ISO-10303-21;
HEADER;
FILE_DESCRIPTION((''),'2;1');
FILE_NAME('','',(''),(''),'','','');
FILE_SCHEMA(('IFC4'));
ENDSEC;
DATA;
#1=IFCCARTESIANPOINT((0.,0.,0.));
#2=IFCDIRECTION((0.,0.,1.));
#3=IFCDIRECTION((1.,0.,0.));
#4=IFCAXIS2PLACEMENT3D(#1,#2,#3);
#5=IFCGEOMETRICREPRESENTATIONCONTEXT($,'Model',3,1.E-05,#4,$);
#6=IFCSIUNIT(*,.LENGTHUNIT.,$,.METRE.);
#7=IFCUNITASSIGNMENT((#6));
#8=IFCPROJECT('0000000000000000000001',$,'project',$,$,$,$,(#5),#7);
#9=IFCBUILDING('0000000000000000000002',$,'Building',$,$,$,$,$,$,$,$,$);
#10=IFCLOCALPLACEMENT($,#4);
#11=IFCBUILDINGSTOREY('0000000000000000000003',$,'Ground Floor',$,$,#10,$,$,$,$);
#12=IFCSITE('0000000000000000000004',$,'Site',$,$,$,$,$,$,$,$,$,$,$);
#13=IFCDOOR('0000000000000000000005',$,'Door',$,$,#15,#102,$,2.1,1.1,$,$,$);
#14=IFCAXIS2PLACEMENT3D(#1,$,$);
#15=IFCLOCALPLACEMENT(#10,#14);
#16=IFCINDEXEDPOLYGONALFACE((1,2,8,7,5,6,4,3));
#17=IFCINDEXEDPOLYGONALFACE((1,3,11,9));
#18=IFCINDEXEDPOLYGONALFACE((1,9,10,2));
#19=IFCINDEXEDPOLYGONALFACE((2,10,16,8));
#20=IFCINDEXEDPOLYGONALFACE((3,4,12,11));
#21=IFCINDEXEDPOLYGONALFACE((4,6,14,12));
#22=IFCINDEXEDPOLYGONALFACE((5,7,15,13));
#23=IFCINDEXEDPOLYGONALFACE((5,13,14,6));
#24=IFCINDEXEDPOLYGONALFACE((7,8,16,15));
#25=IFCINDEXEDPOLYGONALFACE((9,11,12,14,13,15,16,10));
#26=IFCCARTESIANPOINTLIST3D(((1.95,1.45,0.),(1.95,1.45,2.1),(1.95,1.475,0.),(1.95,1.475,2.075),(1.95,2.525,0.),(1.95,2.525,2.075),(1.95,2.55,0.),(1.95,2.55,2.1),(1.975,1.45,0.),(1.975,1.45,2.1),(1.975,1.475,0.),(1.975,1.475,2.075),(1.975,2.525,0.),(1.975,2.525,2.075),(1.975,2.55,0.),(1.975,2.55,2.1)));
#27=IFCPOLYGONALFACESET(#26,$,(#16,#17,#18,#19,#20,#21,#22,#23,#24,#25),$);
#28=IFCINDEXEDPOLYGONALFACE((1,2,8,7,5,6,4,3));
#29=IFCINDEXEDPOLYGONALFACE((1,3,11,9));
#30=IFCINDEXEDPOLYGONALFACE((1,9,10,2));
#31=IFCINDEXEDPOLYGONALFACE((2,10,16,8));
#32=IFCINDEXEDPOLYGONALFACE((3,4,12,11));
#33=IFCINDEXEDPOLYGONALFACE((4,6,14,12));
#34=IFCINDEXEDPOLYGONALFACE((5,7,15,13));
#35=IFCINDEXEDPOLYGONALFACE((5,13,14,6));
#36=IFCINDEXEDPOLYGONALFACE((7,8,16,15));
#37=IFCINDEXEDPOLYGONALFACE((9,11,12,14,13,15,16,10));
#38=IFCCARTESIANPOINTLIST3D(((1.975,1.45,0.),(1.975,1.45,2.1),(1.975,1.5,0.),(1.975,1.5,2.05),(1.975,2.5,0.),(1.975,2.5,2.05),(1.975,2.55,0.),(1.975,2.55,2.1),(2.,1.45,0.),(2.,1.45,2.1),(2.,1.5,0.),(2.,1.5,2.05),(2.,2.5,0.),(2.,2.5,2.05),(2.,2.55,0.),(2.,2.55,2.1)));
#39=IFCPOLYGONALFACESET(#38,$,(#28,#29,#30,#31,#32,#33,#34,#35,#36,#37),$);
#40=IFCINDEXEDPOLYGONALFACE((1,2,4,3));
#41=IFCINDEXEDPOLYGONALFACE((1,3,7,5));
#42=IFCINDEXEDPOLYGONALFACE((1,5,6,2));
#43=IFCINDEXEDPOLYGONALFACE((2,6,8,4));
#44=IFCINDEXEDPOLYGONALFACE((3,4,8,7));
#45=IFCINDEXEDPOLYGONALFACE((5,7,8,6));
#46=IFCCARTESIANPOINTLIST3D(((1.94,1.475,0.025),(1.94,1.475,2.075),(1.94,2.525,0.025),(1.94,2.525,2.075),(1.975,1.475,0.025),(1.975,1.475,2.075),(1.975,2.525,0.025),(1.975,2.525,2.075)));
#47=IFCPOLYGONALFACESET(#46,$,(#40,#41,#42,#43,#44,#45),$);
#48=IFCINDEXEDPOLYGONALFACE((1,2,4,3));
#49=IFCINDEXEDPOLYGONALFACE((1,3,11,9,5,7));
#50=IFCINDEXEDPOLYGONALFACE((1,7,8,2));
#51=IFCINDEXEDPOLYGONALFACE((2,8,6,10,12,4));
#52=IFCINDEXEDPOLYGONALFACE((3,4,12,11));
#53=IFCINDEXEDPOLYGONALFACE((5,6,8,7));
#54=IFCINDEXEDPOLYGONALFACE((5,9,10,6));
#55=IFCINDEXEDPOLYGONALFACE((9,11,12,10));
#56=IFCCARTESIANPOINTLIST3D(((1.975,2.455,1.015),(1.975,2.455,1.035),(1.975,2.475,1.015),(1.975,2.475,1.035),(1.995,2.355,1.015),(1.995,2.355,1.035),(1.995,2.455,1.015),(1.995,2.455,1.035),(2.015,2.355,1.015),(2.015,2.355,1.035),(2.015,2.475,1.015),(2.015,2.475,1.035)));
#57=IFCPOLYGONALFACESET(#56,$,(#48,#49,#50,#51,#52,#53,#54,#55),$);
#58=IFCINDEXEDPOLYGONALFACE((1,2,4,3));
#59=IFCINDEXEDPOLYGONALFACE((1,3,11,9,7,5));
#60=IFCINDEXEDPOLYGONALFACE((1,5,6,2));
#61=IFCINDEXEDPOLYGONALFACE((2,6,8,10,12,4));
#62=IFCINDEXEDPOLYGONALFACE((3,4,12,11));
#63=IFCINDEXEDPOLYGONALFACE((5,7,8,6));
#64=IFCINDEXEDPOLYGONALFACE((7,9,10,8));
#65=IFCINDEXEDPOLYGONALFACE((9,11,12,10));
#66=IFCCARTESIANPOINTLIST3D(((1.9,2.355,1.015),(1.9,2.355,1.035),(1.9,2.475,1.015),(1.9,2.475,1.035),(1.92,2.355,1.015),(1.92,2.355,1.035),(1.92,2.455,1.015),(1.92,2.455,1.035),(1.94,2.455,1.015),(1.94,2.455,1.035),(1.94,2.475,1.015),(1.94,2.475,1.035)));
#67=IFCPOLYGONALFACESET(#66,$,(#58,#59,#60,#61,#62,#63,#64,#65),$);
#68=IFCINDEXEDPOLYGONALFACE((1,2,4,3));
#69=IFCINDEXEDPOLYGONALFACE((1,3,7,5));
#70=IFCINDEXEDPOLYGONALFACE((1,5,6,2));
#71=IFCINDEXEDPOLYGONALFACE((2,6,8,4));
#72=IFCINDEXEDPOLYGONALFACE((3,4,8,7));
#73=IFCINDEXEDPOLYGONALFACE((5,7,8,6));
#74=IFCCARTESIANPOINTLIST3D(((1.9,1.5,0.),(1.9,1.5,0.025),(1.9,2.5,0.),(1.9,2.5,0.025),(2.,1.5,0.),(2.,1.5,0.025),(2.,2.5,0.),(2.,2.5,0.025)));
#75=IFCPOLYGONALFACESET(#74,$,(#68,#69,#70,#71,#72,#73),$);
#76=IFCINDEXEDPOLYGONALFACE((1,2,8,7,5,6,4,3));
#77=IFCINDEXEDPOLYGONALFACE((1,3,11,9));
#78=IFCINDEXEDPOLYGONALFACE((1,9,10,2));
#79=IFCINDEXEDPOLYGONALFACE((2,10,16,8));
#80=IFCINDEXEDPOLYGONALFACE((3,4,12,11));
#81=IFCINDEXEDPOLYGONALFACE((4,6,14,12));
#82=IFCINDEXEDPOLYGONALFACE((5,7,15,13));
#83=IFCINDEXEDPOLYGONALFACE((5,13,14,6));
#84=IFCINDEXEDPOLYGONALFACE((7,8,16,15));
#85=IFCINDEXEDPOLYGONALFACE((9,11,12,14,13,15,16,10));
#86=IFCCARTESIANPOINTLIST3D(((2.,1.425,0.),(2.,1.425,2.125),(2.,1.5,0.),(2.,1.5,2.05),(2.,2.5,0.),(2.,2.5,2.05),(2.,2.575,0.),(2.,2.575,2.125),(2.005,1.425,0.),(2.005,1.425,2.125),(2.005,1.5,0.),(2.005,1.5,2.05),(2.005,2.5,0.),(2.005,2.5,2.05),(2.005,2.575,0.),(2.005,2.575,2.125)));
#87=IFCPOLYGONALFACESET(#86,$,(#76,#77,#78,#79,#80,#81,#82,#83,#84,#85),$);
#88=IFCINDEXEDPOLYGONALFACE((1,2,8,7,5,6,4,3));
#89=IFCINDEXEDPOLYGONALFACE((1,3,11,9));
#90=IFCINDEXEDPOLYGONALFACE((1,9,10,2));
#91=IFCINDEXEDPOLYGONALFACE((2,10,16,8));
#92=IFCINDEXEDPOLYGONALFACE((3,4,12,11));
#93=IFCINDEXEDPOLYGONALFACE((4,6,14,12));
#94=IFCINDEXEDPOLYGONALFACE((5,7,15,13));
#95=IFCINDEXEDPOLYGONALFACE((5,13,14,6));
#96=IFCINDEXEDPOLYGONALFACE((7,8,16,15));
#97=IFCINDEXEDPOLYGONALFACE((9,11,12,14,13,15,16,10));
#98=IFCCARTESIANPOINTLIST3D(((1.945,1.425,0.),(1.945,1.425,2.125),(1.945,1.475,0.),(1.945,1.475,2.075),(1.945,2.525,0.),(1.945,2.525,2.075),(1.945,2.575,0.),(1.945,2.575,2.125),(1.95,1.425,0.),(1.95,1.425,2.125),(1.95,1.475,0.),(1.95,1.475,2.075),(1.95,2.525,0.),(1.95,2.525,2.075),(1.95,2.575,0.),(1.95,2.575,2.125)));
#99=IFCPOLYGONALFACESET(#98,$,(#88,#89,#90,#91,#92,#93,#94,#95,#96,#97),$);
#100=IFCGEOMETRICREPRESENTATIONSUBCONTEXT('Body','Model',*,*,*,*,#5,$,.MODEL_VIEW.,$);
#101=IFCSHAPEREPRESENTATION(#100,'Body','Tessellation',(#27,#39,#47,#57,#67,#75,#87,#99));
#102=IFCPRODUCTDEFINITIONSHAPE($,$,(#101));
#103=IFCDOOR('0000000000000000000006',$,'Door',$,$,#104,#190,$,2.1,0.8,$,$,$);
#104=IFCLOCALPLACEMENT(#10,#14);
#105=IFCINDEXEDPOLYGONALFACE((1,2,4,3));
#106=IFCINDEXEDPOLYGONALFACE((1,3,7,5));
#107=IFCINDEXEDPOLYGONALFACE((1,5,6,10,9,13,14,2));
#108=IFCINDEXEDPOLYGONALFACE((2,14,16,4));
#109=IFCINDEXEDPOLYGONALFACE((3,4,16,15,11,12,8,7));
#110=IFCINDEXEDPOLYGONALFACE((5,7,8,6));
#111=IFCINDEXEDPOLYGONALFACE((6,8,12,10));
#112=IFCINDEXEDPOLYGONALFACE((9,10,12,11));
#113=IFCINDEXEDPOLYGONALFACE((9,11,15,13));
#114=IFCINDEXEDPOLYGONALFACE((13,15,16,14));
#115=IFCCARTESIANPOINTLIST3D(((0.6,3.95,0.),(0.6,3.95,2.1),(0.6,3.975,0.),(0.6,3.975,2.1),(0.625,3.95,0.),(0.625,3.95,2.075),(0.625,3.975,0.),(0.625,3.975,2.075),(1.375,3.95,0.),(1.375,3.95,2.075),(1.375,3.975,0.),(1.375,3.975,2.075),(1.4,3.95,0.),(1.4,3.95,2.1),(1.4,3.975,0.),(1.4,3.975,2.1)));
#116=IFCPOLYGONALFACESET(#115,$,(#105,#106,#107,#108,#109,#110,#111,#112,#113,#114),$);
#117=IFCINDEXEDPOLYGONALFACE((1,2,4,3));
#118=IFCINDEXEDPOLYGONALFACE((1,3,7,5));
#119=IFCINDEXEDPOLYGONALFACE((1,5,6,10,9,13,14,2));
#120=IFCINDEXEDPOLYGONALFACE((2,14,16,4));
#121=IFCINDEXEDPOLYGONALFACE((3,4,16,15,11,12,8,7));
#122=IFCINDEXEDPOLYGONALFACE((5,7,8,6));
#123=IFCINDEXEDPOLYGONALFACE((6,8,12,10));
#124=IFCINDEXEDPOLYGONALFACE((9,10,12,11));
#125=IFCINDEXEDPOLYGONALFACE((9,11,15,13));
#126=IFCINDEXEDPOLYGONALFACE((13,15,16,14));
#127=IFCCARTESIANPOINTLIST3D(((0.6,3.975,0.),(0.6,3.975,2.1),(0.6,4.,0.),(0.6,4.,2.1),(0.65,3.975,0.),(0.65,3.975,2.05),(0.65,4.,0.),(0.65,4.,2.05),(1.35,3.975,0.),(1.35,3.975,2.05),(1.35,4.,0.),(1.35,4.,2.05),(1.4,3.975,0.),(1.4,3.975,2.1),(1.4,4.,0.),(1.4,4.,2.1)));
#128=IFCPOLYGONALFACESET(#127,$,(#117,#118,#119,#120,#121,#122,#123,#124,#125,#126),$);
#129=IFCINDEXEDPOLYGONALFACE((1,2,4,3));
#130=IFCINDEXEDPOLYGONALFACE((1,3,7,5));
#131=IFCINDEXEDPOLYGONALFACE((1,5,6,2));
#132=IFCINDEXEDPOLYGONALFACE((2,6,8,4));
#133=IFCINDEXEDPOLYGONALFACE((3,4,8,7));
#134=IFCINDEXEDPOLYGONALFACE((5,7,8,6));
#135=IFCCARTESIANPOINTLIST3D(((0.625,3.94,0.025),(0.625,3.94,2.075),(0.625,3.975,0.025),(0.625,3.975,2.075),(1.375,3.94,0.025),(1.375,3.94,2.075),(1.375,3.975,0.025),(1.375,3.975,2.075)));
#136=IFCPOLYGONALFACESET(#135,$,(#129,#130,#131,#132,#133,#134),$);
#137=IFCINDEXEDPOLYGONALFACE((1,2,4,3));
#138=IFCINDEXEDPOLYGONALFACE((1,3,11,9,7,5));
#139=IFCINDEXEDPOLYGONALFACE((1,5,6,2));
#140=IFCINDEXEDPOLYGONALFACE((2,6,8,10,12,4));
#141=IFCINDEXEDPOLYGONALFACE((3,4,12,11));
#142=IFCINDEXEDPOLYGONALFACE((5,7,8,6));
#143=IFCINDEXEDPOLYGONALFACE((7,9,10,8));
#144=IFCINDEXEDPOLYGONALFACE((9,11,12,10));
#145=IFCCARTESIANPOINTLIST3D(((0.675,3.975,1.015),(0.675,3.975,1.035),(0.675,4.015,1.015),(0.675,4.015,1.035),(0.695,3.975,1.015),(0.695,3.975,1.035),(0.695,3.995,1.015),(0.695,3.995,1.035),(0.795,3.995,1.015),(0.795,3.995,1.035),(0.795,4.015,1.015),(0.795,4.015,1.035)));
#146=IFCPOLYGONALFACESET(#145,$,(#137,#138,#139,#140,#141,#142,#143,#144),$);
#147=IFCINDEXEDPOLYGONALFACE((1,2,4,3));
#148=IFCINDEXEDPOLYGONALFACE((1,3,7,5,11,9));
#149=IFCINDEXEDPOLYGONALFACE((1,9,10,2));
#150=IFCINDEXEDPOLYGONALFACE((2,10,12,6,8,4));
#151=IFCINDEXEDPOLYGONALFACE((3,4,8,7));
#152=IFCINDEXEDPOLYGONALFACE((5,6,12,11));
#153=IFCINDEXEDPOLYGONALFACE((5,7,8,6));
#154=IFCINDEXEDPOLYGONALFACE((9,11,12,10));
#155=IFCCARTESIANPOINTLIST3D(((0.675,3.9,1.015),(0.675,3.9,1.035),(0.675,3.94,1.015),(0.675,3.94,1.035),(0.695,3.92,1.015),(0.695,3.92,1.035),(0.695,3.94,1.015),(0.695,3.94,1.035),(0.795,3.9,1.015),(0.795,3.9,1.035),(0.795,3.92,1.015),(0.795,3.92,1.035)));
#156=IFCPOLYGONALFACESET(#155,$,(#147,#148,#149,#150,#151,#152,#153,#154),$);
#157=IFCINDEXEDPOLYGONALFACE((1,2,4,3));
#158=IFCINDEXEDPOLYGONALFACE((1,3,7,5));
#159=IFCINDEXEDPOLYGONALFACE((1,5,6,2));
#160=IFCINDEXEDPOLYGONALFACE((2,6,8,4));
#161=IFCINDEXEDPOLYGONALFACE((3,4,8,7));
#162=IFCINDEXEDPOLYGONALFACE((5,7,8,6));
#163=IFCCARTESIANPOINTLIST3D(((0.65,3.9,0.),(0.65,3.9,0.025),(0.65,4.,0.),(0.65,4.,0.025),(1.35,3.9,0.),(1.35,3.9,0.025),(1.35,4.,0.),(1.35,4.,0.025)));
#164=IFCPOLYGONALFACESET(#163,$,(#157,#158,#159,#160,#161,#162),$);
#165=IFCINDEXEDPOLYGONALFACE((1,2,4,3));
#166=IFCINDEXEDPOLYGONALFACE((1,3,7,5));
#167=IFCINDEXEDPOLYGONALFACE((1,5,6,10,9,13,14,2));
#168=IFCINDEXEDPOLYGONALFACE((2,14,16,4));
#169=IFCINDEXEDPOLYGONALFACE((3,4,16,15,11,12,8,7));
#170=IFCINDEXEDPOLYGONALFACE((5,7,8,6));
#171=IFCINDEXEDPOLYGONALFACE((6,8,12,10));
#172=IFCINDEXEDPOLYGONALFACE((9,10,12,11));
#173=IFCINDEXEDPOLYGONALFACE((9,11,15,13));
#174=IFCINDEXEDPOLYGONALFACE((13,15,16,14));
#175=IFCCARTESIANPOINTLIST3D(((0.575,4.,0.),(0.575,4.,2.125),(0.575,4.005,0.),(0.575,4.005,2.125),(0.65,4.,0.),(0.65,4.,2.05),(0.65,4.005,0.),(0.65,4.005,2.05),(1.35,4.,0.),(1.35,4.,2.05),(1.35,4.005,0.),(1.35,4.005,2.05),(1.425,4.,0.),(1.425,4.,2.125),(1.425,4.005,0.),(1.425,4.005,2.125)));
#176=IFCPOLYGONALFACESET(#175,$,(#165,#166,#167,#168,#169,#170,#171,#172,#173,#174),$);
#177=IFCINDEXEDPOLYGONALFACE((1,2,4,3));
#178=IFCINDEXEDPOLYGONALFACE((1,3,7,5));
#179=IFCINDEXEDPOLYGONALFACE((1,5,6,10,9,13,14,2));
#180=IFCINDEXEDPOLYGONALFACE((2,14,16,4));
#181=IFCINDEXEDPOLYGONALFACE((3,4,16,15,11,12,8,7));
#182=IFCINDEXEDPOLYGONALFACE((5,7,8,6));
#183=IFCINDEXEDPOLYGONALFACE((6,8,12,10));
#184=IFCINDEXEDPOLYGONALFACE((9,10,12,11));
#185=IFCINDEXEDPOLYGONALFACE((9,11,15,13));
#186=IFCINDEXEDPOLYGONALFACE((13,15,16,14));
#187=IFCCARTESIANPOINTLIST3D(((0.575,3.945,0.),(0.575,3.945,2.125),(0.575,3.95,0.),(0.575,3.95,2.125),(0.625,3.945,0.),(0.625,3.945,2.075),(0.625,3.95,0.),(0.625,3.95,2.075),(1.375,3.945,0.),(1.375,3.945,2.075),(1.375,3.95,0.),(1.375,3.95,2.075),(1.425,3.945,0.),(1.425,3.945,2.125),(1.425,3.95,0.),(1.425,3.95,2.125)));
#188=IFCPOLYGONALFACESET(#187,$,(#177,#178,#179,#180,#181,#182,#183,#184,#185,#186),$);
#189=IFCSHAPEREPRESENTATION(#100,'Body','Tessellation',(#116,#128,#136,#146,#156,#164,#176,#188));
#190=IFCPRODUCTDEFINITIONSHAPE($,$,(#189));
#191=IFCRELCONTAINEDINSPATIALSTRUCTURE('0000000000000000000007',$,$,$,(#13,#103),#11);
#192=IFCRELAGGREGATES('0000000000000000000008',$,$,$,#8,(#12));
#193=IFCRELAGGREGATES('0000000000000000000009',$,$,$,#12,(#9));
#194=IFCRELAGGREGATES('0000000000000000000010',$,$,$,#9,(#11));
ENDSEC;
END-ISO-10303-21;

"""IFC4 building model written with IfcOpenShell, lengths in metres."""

from ifc_helpers import new_model, si_unit, frame, origin_with_axes, place, context, subcontext, project, spatial, line, indexed_curve, outline, extrude, element, save


model = new_model("IFC4")

# Units and contexts
model_context = context("Model", 3, precision=1e-05, world=origin_with_axes())
body_context = subcontext(model_context, "Body", "Model", "MODEL_VIEW")
ifc_project = project(units=[si_unit("LENGTHUNIT", "METRE")], contexts=[model_context])

# Site, building, storey
site = spatial("IfcSite", under=ifc_project, Name="Site")
building = spatial("IfcBuilding", under=site, Name="Building")
storey_placement = place(None, origin_with_axes())
storey = spatial("IfcBuildingStorey", under=building, at=storey_placement, Name="Ground Floor")

# Doors
door_1_placement = place(storey_placement, frame((2.0, 1.45, 0.0), z_axis=(0.0, 0.0, 1.0), x_axis=(0.0, 1.0, 0.0)))
element("IfcDoor", 1, at=door_1_placement, inside=storey, Name="Door", OverallHeight=2.1, OverallWidth=1.1, context=body_context, shape_type="SweptSolid", body=[
    extrude(outline(indexed_curve([(0.0, 0.0), (0.0, 2.1), (1.1, 2.1), (1.1, 0.0), (1.075, 0.0), (1.075, 2.075), (0.025, 2.075), (0.025, 0.0)], segments=[line(1, 2, 3, 4, 5, 6, 7, 8, 1)])), frame((0.0, 0.025, 0.0), z_axis=(0.0, -1.0, 0.0), x_axis=(1.0, 0.0, 0.0)), (0.0, 0.0, -1.0), 0.025),
    extrude(outline(indexed_curve([(0.0, 0.0), (0.0, 2.1), (1.1, 2.1), (1.1, 0.0), (1.05, 0.0), (1.05, 2.05), (0.05, 2.05), (0.05, 0.0)], segments=[line(1, 2, 3, 4, 5, 6, 7, 8, 1)])), frame((0.0, 0.0, 0.0), z_axis=(0.0, -1.0, 0.0), x_axis=(1.0, 0.0, 0.0)), (0.0, 0.0, -1.0), 0.025),
    extrude(outline(indexed_curve([(0.0, 0.0), (1.05, 0.0), (1.05, 0.035), (0.0, 0.035)], segments=[line(1, 2, 3, 4, 1)])), frame((0.025, 0.025, 0.025), z_axis=(0.0, 0.0, 1.0), x_axis=(1.0, 0.0, 0.0)), (0.0, 0.0, 1.0), 2.05),
    extrude(outline(indexed_curve([(0.0, 0.0), (0.0, -0.04), (-0.12, -0.04), (-0.12, -0.02), (-0.02, -0.02), (-0.02, 0.0)], segments=[line(1, 2, 3, 4, 5, 6, 1)])), frame((1.025, 0.025, 1.015), z_axis=(0.0, 0.0, 1.0), x_axis=(1.0, 0.0, 0.0)), (0.0, 0.0, 1.0), 0.02),
    extrude(outline(indexed_curve([(0.0, 0.0), (0.0, 0.04), (-0.12, 0.04), (-0.12, 0.02), (-0.02, 0.02), (-0.02, 0.0)], segments=[line(1, 2, 3, 4, 5, 6, 1)])), frame((1.025, 0.06, 1.015), z_axis=(0.0, 0.0, 1.0), x_axis=(1.0, 0.0, 0.0)), (0.0, 0.0, 1.0), 0.02),
    extrude(outline(indexed_curve([(0.0, 0.0), (1.0, 0.0), (1.0, 0.1), (0.0, 0.1)], segments=[line(1, 2, 3, 4, 1)])), frame((0.05, 0.0, 0.0), z_axis=(0.0, 0.0, 1.0), x_axis=(1.0, 0.0, 0.0)), (0.0, 0.0, 1.0), 0.025),
    extrude(outline(indexed_curve([(0.0, 0.0), (0.0, 2.125), (1.15, 2.125), (1.15, 0.0), (1.075, 0.0), (1.075, 2.05), (0.075, 2.05), (0.075, 0.0)], segments=[line(1, 2, 3, 4, 5, 6, 7, 8, 1)])), frame((-0.025, -0.005, 0.0), z_axis=(0.0, -1.0, 0.0), x_axis=(1.0, 0.0, 0.0)), (0.0, 0.0, -1.0), 0.005),
    extrude(outline(indexed_curve([(0.0, 0.0), (0.0, 2.125), (1.15, 2.125), (1.15, 0.0), (1.1, 0.0), (1.1, 2.075), (0.05, 2.075), (0.05, 0.0)], segments=[line(1, 2, 3, 4, 5, 6, 7, 8, 1)])), frame((-0.025, 0.05, 0.0), z_axis=(0.0, -1.0, 0.0), x_axis=(1.0, 0.0, 0.0)), (0.0, 0.0, -1.0), 0.005),
])
door_2_placement = place(storey_placement, frame((1.4, 4.0, 0.0), z_axis=(0.0, 0.0, 1.0), x_axis=(-1.0, 0.0, 0.0)))
element("IfcDoor", 2, at=door_2_placement, inside=storey, Name="Door", OverallHeight=2.1, OverallWidth=0.8, context=body_context, shape_type="SweptSolid", body=[
    extrude(outline(indexed_curve([(0.0, 0.0), (0.0, 2.1), (0.8, 2.1), (0.8, 0.0), (0.775, 0.0), (0.775, 2.075), (0.025, 2.075), (0.025, 0.0)], segments=[line(1, 2, 3, 4, 5, 6, 7, 8, 1)])), frame((0.0, 0.025, 0.0), z_axis=(0.0, -1.0, 0.0), x_axis=(1.0, 0.0, 0.0)), (0.0, 0.0, -1.0), 0.025),
    extrude(outline(indexed_curve([(0.0, 0.0), (0.0, 2.1), (0.8, 2.1), (0.8, 0.0), (0.75, 0.0), (0.75, 2.05), (0.05, 2.05), (0.05, 0.0)], segments=[line(1, 2, 3, 4, 5, 6, 7, 8, 1)])), frame((0.0, 0.0, 0.0), z_axis=(0.0, -1.0, 0.0), x_axis=(1.0, 0.0, 0.0)), (0.0, 0.0, -1.0), 0.025),
    extrude(outline(indexed_curve([(0.0, 0.0), (0.75, 0.0), (0.75, 0.035), (0.0, 0.035)], segments=[line(1, 2, 3, 4, 1)])), frame((0.025, 0.025, 0.025), z_axis=(0.0, 0.0, 1.0), x_axis=(1.0, 0.0, 0.0)), (0.0, 0.0, 1.0), 2.05),
    extrude(outline(indexed_curve([(0.0, 0.0), (0.0, -0.04), (-0.12, -0.04), (-0.12, -0.02), (-0.02, -0.02), (-0.02, 0.0)], segments=[line(1, 2, 3, 4, 5, 6, 1)])), frame((0.725, 0.025, 1.015), z_axis=(0.0, 0.0, 1.0), x_axis=(1.0, 0.0, 0.0)), (0.0, 0.0, 1.0), 0.02),
    extrude(outline(indexed_curve([(0.0, 0.0), (0.0, 0.04), (-0.12, 0.04), (-0.12, 0.02), (-0.02, 0.02), (-0.02, 0.0)], segments=[line(1, 2, 3, 4, 5, 6, 1)])), frame((0.725, 0.06, 1.015), z_axis=(0.0, 0.0, 1.0), x_axis=(1.0, 0.0, 0.0)), (0.0, 0.0, 1.0), 0.02),
    extrude(outline(indexed_curve([(0.0, 0.0), (0.7, 0.0), (0.7, 0.1), (0.0, 0.1)], segments=[line(1, 2, 3, 4, 1)])), frame((0.05, 0.0, 0.0), z_axis=(0.0, 0.0, 1.0), x_axis=(1.0, 0.0, 0.0)), (0.0, 0.0, 1.0), 0.025),
    extrude(outline(indexed_curve([(0.0, 0.0), (0.0, 2.125), (0.85, 2.125), (0.85, 0.0), (0.775, 0.0), (0.775, 2.05), (0.075, 2.05), (0.075, 0.0)], segments=[line(1, 2, 3, 4, 5, 6, 7, 8, 1)])), frame((-0.025, -0.005, 0.0), z_axis=(0.0, -1.0, 0.0), x_axis=(1.0, 0.0, 0.0)), (0.0, 0.0, -1.0), 0.005),
    extrude(outline(indexed_curve([(0.0, 0.0), (0.0, 2.125), (0.85, 2.125), (0.85, 0.0), (0.8, 0.0), (0.8, 2.075), (0.05, 2.075), (0.05, 0.0)], segments=[line(1, 2, 3, 4, 5, 6, 7, 8, 1)])), frame((-0.025, 0.05, 0.0), z_axis=(0.0, -1.0, 0.0), x_axis=(1.0, 0.0, 0.0)), (0.0, 0.0, -1.0), 0.005),
])

save(model, "model.ifc")
